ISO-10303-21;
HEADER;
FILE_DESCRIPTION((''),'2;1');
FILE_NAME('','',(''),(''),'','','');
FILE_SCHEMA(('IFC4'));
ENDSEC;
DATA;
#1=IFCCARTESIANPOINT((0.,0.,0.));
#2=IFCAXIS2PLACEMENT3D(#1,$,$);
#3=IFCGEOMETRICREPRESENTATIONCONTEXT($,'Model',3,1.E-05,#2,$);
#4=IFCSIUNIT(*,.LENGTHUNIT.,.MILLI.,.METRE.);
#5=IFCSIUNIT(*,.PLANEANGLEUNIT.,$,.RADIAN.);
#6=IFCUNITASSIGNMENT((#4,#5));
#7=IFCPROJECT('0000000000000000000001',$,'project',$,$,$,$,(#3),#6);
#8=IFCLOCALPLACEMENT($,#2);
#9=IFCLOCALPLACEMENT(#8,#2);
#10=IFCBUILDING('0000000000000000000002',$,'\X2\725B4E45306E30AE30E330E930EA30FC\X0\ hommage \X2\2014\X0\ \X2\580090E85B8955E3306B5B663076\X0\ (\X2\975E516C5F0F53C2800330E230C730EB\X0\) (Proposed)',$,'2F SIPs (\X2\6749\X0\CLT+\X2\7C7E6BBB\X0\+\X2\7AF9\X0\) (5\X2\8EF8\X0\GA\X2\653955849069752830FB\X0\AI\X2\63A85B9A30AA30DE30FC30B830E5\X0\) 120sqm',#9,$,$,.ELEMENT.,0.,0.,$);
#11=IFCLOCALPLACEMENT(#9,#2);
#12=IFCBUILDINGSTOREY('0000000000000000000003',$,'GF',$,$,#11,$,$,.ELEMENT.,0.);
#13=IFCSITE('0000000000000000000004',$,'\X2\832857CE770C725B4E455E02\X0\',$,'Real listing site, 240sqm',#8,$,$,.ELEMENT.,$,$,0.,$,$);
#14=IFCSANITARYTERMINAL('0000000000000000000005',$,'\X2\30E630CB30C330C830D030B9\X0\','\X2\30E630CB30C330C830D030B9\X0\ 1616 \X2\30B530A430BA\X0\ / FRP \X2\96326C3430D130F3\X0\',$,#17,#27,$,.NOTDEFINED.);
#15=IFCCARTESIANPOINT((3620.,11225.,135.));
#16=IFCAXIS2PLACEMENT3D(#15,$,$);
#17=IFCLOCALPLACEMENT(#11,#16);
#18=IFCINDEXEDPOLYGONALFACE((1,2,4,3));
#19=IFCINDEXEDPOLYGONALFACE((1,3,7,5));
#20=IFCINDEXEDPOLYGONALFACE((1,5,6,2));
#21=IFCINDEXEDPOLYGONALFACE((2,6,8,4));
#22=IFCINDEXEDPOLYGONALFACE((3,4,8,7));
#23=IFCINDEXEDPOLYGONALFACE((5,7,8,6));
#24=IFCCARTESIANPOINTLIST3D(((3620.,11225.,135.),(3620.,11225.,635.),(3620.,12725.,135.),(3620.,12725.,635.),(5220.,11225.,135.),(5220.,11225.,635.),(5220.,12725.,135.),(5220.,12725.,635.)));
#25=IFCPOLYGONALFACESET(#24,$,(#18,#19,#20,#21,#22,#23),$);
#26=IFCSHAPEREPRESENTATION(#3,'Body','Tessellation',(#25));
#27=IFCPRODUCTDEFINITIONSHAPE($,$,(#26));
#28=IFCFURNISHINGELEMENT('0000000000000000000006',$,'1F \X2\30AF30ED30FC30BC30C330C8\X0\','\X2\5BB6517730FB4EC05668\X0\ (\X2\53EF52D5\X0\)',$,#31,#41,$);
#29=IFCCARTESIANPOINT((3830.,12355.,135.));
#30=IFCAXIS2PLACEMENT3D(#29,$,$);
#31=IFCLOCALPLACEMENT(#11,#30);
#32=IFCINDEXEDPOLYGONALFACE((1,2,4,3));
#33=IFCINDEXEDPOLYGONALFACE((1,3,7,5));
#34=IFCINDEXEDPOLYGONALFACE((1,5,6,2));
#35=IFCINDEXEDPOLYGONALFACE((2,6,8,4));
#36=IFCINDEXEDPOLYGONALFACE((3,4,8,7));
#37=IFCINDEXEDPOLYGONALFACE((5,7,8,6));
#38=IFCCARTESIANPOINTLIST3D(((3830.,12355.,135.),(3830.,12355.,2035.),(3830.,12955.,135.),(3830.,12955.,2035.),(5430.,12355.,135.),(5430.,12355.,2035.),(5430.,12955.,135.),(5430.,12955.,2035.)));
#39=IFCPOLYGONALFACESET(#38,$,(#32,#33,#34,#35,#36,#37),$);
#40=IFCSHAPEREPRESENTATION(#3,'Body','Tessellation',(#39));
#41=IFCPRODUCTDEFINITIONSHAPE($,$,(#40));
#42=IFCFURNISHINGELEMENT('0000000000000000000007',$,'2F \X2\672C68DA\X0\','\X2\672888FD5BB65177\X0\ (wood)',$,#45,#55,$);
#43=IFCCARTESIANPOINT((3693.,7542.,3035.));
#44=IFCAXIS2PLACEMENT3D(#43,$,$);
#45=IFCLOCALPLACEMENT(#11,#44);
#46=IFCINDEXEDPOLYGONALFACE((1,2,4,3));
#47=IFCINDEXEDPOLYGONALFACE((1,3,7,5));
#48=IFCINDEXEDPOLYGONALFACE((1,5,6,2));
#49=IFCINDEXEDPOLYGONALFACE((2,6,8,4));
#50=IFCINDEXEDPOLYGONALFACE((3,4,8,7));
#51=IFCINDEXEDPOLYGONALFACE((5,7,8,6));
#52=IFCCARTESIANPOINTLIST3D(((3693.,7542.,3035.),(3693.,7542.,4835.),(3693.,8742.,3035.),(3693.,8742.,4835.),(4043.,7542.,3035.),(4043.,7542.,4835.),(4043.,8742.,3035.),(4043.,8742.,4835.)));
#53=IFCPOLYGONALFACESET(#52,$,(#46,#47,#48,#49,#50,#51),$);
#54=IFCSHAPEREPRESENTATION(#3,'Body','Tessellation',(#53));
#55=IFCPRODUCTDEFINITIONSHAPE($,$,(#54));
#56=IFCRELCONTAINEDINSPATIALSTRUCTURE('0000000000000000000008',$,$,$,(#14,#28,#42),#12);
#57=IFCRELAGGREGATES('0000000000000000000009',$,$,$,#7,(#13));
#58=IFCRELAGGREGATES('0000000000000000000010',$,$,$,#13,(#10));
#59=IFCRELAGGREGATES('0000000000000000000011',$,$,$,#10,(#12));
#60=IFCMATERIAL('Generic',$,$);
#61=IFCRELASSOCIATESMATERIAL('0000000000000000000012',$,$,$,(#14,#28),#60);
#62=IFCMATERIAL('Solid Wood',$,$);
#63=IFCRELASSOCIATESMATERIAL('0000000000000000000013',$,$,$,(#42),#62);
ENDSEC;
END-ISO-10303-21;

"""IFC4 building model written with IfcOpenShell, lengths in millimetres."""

from ifc_helpers import new_model, si_unit, frame, frame_2d, origin, place, context, project, spatial, rectangle, extrude, material, element, save


model = new_model("IFC4")

# Units and contexts
model_context = context("Model", 3, precision=1e-05, world=origin())
ifc_project = project(units=[si_unit("LENGTHUNIT", "METRE", prefix="MILLI"), si_unit("PLANEANGLEUNIT", "RADIAN")], contexts=[model_context])

# Site, building, storey
site_placement = place(None, origin())
site = spatial("IfcSite", under=ifc_project, at=site_placement, Name="茨城県牛久市", ObjectType="Real listing site, 240sqm", CompositionType="ELEMENT", RefElevation=0.0)
building_placement = place(site_placement, origin())
building = spatial("IfcBuilding", under=site, at=building_placement, Name="牛久のギャラリー hommage — 堀部安嗣に学ぶ (非公式参考モデル) (Proposed)", ObjectType="2F SIPs (杉CLT+籾殻+竹) (5軸GA改善適用・AI推定オマージュ) 120sqm", CompositionType="ELEMENT", ElevationOfRefHeight=0.0, ElevationOfTerrain=0.0)
storey_placement = place(building_placement, origin())
storey = spatial("IfcBuildingStorey", under=building, at=storey_placement, Name="GF", CompositionType="ELEMENT", Elevation=0.0)

# Shared definitions
ifc_material_1 = material(Name="Solid Wood")

# Shared definitions
ifc_material_2 = material(Name="Generic")

# Sanitary terminal
sanitary_terminal_placement = place(storey_placement, frame((3620.0, 11225.0, 135.0)))
element("IfcSanitaryTerminal", 1, at=sanitary_terminal_placement, inside=storey, material=ifc_material_2, Name="ユニットバス", Description="ユニットバス 1616 サイズ / FRP 防水パン", PredefinedType="NOTDEFINED", context=model_context, shape_type="SweptSolid", body=[
    extrude(rectangle(XDim=1600.0, YDim=1500.0, at=frame_2d((800.0, 750.0))), frame((3620.0, 11225.0, 135.0)), (0.0, 0.0, 1.0), 500.0),
])

# Furnishing elements
furnishing_1_placement = place(storey_placement, frame((3830.0, 12355.0, 135.0)))
element("IfcFurnishingElement", 2, at=furnishing_1_placement, inside=storey, material=ifc_material_2, Name="1F クローゼット", Description="家具・什器 (可動)", context=model_context, shape_type="SweptSolid", body=[
    extrude(rectangle(XDim=1600.0, YDim=600.0, at=frame_2d((800.0, 300.0))), frame((3830.0, 12355.0, 135.0)), (0.0, 0.0, 1.0), 1900.0),
])
furnishing_2_placement = place(storey_placement, frame((3693.0, 7542.0, 3035.0)))
element("IfcFurnishingElement", 3, at=furnishing_2_placement, inside=storey, material=ifc_material_1, Name="2F 本棚", Description="木製家具 (wood)", context=model_context, shape_type="SweptSolid", body=[
    extrude(rectangle(XDim=350.0, YDim=1200.0, at=frame_2d((175.0, 600.0))), frame((3693.0, 7542.0, 3035.0)), (0.0, 0.0, 1.0), 1800.0),
])

save(model, "model.ifc")
